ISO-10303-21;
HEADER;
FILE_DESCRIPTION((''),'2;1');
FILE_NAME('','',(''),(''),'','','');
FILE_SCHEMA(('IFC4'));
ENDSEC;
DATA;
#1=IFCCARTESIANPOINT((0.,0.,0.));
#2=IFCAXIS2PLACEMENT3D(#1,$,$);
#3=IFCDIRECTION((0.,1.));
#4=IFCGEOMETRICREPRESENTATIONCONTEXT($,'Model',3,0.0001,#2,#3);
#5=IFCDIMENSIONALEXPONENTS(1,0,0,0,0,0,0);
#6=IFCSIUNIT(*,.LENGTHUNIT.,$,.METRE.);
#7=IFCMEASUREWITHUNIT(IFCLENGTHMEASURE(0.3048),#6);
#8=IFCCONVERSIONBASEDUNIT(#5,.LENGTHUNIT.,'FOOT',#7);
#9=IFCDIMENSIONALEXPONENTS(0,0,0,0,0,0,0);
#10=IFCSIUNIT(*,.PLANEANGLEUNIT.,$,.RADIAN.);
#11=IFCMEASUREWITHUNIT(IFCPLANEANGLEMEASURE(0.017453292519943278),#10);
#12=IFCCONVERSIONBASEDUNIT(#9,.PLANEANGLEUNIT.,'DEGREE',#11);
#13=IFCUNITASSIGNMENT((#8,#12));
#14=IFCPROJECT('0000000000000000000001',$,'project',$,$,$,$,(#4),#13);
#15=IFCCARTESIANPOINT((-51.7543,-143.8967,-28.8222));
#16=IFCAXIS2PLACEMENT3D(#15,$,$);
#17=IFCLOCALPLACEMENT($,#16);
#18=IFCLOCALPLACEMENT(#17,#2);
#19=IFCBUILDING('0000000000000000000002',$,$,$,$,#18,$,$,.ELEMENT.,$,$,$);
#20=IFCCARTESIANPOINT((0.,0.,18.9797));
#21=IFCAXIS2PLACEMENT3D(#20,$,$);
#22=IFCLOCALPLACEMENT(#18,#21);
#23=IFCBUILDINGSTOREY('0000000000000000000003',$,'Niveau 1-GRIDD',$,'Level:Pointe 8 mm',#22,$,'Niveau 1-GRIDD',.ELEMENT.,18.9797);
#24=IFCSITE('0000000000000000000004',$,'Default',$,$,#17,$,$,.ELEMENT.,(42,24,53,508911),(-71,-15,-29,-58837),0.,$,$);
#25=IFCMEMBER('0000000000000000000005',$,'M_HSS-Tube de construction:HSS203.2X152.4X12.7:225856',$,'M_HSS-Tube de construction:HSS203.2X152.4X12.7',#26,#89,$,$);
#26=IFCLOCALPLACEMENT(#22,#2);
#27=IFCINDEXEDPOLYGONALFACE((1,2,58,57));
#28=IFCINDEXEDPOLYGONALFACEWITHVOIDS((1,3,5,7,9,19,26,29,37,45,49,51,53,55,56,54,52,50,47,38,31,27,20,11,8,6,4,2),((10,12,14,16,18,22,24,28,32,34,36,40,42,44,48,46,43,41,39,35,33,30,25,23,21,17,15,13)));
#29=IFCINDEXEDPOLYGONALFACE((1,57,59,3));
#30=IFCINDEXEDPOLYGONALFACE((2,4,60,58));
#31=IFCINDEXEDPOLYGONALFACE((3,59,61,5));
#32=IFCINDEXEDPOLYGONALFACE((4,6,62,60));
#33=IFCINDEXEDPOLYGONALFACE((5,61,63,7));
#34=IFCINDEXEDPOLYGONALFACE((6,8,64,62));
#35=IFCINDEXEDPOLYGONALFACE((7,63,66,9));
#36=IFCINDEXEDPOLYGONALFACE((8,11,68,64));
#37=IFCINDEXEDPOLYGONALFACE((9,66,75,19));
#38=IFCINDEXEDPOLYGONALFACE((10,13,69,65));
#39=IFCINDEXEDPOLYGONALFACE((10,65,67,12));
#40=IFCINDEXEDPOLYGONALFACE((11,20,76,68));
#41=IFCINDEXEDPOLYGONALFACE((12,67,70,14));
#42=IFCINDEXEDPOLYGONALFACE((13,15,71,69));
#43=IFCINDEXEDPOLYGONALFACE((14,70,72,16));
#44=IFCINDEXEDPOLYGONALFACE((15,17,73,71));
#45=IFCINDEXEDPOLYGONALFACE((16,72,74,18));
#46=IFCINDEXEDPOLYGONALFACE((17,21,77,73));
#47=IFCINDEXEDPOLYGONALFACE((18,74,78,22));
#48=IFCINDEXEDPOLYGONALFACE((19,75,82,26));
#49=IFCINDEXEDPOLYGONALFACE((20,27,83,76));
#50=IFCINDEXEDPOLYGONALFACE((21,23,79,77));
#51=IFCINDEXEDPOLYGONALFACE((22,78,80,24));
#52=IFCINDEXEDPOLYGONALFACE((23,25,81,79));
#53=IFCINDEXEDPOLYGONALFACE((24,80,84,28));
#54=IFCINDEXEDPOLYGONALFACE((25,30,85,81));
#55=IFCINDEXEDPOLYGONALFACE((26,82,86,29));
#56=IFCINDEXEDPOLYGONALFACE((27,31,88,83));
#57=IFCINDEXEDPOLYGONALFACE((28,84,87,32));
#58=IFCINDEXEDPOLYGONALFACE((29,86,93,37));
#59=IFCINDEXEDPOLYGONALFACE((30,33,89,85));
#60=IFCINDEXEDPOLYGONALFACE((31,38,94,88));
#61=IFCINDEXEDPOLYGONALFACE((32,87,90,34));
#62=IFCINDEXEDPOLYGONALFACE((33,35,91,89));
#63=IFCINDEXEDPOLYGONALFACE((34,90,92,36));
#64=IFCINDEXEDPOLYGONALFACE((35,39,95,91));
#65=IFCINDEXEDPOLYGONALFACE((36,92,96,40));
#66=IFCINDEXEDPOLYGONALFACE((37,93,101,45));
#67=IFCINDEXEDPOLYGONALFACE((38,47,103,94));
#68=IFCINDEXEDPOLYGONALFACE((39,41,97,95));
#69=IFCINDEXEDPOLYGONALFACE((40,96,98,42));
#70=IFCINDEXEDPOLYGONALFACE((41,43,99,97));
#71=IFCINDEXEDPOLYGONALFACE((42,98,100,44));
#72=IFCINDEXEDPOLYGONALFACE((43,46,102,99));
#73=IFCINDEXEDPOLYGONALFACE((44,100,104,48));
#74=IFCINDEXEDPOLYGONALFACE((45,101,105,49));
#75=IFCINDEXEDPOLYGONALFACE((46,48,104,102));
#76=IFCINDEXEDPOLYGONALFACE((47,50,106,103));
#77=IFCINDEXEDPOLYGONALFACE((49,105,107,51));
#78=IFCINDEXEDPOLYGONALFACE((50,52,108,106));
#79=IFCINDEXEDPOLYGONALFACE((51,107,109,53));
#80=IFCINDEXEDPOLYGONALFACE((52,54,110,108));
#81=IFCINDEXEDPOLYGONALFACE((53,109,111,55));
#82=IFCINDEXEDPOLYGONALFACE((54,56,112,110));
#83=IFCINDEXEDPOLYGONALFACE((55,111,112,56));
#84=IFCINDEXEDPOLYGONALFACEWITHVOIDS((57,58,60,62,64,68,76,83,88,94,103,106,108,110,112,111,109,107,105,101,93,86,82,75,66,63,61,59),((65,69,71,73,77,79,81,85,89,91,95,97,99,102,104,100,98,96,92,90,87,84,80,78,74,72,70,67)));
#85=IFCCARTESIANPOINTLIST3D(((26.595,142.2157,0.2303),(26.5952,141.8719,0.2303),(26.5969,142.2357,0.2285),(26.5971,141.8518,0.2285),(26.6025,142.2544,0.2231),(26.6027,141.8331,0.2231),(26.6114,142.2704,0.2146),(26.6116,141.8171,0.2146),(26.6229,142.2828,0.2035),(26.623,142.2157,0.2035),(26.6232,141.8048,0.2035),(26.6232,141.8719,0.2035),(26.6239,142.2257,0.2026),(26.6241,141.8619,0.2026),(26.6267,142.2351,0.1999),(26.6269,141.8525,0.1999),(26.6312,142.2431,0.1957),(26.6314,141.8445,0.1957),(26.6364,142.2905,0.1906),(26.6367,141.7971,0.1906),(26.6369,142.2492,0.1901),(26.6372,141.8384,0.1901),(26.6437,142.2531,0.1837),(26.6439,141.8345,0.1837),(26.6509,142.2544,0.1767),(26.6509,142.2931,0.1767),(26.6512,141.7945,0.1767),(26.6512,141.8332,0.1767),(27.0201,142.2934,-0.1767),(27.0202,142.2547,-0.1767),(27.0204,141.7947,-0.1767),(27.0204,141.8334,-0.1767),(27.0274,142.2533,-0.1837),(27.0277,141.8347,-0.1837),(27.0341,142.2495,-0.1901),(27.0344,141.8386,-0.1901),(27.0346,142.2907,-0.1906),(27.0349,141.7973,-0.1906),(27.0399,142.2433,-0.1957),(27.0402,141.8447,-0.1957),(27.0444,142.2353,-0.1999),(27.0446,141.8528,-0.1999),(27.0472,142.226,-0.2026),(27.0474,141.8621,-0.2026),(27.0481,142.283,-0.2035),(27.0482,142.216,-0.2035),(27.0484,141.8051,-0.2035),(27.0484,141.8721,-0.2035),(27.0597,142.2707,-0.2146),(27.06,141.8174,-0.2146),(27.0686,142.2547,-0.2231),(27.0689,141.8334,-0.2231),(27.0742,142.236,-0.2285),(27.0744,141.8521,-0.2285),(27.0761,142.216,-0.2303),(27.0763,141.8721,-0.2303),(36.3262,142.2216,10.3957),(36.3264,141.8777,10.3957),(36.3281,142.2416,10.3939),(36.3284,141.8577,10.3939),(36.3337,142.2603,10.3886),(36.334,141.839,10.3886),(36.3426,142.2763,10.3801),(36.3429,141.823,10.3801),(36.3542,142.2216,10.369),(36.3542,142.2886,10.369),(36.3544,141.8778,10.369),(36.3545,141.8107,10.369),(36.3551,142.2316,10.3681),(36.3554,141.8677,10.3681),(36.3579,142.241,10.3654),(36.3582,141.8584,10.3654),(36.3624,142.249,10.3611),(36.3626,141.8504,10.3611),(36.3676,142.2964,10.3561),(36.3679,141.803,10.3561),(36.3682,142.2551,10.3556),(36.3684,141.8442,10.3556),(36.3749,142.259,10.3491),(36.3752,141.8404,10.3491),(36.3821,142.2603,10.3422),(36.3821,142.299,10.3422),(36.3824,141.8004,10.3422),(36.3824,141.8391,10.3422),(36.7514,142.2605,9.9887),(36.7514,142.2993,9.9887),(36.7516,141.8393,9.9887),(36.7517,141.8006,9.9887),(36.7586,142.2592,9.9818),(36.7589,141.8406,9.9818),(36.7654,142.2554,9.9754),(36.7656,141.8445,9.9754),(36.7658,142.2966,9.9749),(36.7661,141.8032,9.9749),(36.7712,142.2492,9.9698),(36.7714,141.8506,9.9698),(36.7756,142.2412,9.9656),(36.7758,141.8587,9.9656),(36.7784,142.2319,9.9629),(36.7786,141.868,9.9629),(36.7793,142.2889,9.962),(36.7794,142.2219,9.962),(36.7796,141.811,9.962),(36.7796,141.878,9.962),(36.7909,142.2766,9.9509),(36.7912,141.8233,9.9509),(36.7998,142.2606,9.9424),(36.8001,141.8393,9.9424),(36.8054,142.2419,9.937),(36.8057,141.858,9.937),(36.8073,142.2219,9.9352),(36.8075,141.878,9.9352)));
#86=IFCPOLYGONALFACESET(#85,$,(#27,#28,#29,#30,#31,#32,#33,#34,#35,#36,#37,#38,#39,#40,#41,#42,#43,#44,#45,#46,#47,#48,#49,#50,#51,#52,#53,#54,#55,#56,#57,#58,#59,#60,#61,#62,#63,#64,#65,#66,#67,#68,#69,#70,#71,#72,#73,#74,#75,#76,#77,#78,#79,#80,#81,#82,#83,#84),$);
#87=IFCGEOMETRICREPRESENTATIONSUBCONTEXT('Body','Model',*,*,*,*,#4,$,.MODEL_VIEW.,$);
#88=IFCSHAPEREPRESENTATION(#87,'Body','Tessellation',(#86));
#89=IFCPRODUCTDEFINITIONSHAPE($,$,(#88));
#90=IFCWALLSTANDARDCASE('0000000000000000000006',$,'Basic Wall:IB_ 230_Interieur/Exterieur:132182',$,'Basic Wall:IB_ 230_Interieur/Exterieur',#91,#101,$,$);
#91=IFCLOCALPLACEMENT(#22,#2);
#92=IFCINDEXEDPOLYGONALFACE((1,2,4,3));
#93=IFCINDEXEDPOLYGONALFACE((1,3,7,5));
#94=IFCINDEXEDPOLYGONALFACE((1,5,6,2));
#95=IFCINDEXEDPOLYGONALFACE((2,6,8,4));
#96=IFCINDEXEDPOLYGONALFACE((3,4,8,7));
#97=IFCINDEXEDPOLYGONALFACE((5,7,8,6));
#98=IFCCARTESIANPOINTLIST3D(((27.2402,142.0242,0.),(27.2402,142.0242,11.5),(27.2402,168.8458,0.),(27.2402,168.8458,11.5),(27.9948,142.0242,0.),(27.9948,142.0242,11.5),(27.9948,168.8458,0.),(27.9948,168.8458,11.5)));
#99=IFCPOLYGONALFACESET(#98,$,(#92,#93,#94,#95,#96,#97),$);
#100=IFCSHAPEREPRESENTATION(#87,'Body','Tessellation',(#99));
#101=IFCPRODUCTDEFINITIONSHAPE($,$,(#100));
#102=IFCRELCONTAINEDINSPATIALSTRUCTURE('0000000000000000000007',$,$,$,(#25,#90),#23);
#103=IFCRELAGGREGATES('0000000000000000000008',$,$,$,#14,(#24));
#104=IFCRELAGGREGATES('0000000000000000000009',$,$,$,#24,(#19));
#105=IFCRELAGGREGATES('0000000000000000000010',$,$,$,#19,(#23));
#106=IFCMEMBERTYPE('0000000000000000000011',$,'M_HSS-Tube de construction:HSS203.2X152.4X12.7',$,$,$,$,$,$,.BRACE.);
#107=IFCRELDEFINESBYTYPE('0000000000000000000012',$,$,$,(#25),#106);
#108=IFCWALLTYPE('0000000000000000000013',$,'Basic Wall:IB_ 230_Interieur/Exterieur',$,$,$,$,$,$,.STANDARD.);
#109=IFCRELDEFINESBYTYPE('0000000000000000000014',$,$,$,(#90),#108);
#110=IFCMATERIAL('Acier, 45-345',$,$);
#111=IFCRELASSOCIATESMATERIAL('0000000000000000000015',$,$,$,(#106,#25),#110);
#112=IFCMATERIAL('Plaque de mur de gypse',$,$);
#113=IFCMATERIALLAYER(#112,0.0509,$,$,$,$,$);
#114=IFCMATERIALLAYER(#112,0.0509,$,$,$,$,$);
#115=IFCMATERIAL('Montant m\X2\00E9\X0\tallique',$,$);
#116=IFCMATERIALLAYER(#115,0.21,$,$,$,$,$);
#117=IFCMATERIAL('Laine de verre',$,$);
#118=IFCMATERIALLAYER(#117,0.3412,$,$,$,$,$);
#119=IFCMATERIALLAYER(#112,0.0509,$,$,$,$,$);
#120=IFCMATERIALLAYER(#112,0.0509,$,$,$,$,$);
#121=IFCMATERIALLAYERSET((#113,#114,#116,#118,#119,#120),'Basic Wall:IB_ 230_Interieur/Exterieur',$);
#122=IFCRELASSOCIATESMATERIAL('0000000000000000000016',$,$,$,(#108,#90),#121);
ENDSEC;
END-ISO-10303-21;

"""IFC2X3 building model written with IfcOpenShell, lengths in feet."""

from ifc_helpers import new_model, entity, si_unit, converted_unit, direction, frame, frame_2d, origin, place, context, subcontext, project, spatial, polyline, circle_curve, parameter, trimmed, segment, composite_curve, rectangle, outline, extrude, source, transform, mapped, material, layer, layer_set, layer_usage, type_object, type_shapes, element, save


model = new_model("IFC2X3")

# Units and contexts
model_context = context("Model", 3, precision=0.0001, world=origin(), true_north=direction((0.0, 1.0)))
body_context = subcontext(model_context, "Body", "Model", "MODEL_VIEW")
ifc_project = project(units=[converted_unit("LENGTHUNIT", "FOOT", entity("IfcLengthMeasure", 0.3048), si_unit("LENGTHUNIT", "METRE"), dimensions=[1, 0, 0, 0, 0, 0, 0]), converted_unit("PLANEANGLEUNIT", "DEGREE", entity("IfcPlaneAngleMeasure", 0.017453292519943278), si_unit("PLANEANGLEUNIT", "RADIAN"), dimensions=[0, 0, 0, 0, 0, 0, 0])], contexts=[model_context])

# Site, building, storey
site_placement = place(None, frame((-51.7543, -143.8967, -28.8222)))
site = spatial("IfcSite", under=ifc_project, at=site_placement, Name="Default", CompositionType="ELEMENT", RefLatitude=(42, 24, 53, 508911), RefLongitude=(-71, -15, -29, -58837), RefElevation=0.0)
building_placement = place(site_placement, origin())
building = spatial("IfcBuilding", under=site, at=building_placement, CompositionType="ELEMENT")
storey_placement = place(building_placement, frame((0.0, 0.0, 18.9797)))
storey = spatial("IfcBuildingStorey", under=building, at=storey_placement, Name="Niveau 1-GRIDD", ObjectType="Level:Pointe 8 mm", LongName="Niveau 1-GRIDD", CompositionType="ELEMENT", Elevation=18.9797)

# Member
ifc_material_1 = material(Name="Acier, 45-345")
member_type = type_object("IfcMemberType", Name="M_HSS-Tube de construction:HSS203.2X152.4X12.7", PredefinedType="BRACE", material=ifc_material_1)
shared_shape_1 = source(origin(), body_context, "Body", "SweptSolid", [
    extrude(outline(composite_curve([segment(trimmed(circle_curve(frame_2d((-0.1719, -0.2556), x_axis=(1.0, 0.0)), 0.0774), [parameter(180.0)], [parameter(270.0)], True, "PARAMETER"), True, "CONTINUOUS"), segment(polyline([(-0.1719, -0.333), (0.1719, -0.333)]), True, "CONTINUOUS"), segment(trimmed(circle_curve(frame_2d((0.1719, -0.2556), x_axis=(1.0, 0.0)), 0.0774), [parameter(270.0)], [parameter(0.0)], True, "PARAMETER"), True, "CONTINUOUS"), segment(polyline([(0.2493, -0.2556), (0.2493, 0.2556)]), True, "CONTINUOUS"), segment(trimmed(circle_curve(frame_2d((0.1719, 0.2556), x_axis=(1.0, 0.0)), 0.0774), [parameter(360.0)], [parameter(90.0)], True, "PARAMETER"), True, "CONTINUOUS"), segment(polyline([(0.1719, 0.333), (-0.1719, 0.333)]), True, "CONTINUOUS"), segment(trimmed(circle_curve(frame_2d((-0.1719, 0.2556), x_axis=(1.0, 0.0)), 0.0774), [parameter(90.0)], [parameter(180.0)], True, "PARAMETER"), True, "CONTINUOUS"), segment(polyline([(-0.2493, 0.2556), (-0.2493, -0.2556)]), True, "CONTINUOUS")], self_intersect=False), holes=[composite_curve([segment(polyline([(0.1719, -0.2943), (-0.1719, -0.2943)]), True, "CONTINUOUS"), segment(trimmed(circle_curve(frame_2d((-0.1719, -0.2556), x_axis=(1.0, 0.0)), 0.0387), [parameter(180.0)], [parameter(270.0)], True, "PARAMETER"), False, "CONTINUOUS"), segment(polyline([(-0.2106, -0.2556), (-0.2106, 0.2556)]), True, "CONTINUOUS"), segment(trimmed(circle_curve(frame_2d((-0.1719, 0.2556), x_axis=(1.0, 0.0)), 0.0387), [parameter(90.0)], [parameter(180.0)], True, "PARAMETER"), False, "CONTINUOUS"), segment(polyline([(-0.1719, 0.2943), (0.1719, 0.2943)]), True, "CONTINUOUS"), segment(trimmed(circle_curve(frame_2d((0.1719, 0.2556), x_axis=(1.0, 0.0)), 0.0387), [parameter(0.0)], [parameter(90.0)], True, "PARAMETER"), False, "CONTINUOUS"), segment(polyline([(0.2106, 0.2556), (0.2106, -0.2556)]), True, "CONTINUOUS"), segment(trimmed(circle_curve(frame_2d((0.1719, -0.2556), x_axis=(1.0, 0.0)), 0.0387), [parameter(270.0)], [parameter(0.0)], True, "PARAMETER"), False, "CONTINUOUS")], self_intersect=False)]), frame((-7.0362, 0.0, 0.0), z_axis=(1.0, 0.0, 0.0), x_axis=(0.0, -1.0, 0.0)), (0.0, 0.0, 1.0), 14.0724),
])
type_shapes(member_type, [shared_shape_1])
member_placement = place(storey_placement, frame((31.7013, 142.0469, 5.0827), z_axis=(-0.722367, -0.000437, 0.691509), x_axis=(0.691509, 0.000419, 0.722367)))
element("IfcMember", 1, at=member_placement, inside=storey, type_object=member_type, material=ifc_material_1, Name="M_HSS-Tube de construction:HSS203.2X152.4X12.7:225856", ObjectType="M_HSS-Tube de construction:HSS203.2X152.4X12.7", context=body_context, shape_type="MappedRepresentation", body=[
    mapped(shared_shape_1, transform((0.0, 0.0, 0.0), scale=1.0)),
])

# Wall
ifc_material_2 = material(Name="Plaque de mur de gypse")
ifc_layer_1 = layer(ifc_material_2, 0.0509)
ifc_layer_2 = layer(ifc_material_2, 0.0509)
ifc_material_3 = material(Name="Montant métallique")
ifc_layer_3 = layer(ifc_material_3, 0.21)
ifc_material_4 = material(Name="Laine de verre")
ifc_layer_4 = layer(ifc_material_4, 0.3412)
ifc_layer_5 = layer(ifc_material_2, 0.0509)
ifc_layer_6 = layer(ifc_material_2, 0.0509)
ifc_layer_set_1 = layer_set([ifc_layer_1, ifc_layer_2, ifc_layer_3, ifc_layer_4, ifc_layer_5, ifc_layer_6], Name="Basic Wall:IB_ 230_Interieur/Exterieur")
ifc_layer_usage_1 = layer_usage(ifc_layer_set_1, "AXIS2", "NEGATIVE", 0.3773)
wall_type_1 = type_object("IfcWallType", Name="Basic Wall:IB_ 230_Interieur/Exterieur", PredefinedType="STANDARD", material=ifc_layer_set_1)
wall_1_placement = place(storey_placement, frame((27.6175, 142.0242, 0.0), z_axis=(0.0, 0.0, 1.0), x_axis=(0.0, 1.0, 0.0)))
element("IfcWallStandardCase", 2, at=wall_1_placement, inside=storey, type_object=wall_type_1, material=ifc_layer_usage_1, Name="Basic Wall:IB_ 230_Interieur/Exterieur:132182", ObjectType="Basic Wall:IB_ 230_Interieur/Exterieur", context=body_context, shape_type="SweptSolid", body=[
    extrude(rectangle(XDim=26.8216, YDim=0.7546, at=frame_2d((13.4108, 0.0), x_axis=(-1.0, 0.0))), origin(), (0.0, 0.0, 1.0), 11.5),
])

save(model, "model.ifc")
